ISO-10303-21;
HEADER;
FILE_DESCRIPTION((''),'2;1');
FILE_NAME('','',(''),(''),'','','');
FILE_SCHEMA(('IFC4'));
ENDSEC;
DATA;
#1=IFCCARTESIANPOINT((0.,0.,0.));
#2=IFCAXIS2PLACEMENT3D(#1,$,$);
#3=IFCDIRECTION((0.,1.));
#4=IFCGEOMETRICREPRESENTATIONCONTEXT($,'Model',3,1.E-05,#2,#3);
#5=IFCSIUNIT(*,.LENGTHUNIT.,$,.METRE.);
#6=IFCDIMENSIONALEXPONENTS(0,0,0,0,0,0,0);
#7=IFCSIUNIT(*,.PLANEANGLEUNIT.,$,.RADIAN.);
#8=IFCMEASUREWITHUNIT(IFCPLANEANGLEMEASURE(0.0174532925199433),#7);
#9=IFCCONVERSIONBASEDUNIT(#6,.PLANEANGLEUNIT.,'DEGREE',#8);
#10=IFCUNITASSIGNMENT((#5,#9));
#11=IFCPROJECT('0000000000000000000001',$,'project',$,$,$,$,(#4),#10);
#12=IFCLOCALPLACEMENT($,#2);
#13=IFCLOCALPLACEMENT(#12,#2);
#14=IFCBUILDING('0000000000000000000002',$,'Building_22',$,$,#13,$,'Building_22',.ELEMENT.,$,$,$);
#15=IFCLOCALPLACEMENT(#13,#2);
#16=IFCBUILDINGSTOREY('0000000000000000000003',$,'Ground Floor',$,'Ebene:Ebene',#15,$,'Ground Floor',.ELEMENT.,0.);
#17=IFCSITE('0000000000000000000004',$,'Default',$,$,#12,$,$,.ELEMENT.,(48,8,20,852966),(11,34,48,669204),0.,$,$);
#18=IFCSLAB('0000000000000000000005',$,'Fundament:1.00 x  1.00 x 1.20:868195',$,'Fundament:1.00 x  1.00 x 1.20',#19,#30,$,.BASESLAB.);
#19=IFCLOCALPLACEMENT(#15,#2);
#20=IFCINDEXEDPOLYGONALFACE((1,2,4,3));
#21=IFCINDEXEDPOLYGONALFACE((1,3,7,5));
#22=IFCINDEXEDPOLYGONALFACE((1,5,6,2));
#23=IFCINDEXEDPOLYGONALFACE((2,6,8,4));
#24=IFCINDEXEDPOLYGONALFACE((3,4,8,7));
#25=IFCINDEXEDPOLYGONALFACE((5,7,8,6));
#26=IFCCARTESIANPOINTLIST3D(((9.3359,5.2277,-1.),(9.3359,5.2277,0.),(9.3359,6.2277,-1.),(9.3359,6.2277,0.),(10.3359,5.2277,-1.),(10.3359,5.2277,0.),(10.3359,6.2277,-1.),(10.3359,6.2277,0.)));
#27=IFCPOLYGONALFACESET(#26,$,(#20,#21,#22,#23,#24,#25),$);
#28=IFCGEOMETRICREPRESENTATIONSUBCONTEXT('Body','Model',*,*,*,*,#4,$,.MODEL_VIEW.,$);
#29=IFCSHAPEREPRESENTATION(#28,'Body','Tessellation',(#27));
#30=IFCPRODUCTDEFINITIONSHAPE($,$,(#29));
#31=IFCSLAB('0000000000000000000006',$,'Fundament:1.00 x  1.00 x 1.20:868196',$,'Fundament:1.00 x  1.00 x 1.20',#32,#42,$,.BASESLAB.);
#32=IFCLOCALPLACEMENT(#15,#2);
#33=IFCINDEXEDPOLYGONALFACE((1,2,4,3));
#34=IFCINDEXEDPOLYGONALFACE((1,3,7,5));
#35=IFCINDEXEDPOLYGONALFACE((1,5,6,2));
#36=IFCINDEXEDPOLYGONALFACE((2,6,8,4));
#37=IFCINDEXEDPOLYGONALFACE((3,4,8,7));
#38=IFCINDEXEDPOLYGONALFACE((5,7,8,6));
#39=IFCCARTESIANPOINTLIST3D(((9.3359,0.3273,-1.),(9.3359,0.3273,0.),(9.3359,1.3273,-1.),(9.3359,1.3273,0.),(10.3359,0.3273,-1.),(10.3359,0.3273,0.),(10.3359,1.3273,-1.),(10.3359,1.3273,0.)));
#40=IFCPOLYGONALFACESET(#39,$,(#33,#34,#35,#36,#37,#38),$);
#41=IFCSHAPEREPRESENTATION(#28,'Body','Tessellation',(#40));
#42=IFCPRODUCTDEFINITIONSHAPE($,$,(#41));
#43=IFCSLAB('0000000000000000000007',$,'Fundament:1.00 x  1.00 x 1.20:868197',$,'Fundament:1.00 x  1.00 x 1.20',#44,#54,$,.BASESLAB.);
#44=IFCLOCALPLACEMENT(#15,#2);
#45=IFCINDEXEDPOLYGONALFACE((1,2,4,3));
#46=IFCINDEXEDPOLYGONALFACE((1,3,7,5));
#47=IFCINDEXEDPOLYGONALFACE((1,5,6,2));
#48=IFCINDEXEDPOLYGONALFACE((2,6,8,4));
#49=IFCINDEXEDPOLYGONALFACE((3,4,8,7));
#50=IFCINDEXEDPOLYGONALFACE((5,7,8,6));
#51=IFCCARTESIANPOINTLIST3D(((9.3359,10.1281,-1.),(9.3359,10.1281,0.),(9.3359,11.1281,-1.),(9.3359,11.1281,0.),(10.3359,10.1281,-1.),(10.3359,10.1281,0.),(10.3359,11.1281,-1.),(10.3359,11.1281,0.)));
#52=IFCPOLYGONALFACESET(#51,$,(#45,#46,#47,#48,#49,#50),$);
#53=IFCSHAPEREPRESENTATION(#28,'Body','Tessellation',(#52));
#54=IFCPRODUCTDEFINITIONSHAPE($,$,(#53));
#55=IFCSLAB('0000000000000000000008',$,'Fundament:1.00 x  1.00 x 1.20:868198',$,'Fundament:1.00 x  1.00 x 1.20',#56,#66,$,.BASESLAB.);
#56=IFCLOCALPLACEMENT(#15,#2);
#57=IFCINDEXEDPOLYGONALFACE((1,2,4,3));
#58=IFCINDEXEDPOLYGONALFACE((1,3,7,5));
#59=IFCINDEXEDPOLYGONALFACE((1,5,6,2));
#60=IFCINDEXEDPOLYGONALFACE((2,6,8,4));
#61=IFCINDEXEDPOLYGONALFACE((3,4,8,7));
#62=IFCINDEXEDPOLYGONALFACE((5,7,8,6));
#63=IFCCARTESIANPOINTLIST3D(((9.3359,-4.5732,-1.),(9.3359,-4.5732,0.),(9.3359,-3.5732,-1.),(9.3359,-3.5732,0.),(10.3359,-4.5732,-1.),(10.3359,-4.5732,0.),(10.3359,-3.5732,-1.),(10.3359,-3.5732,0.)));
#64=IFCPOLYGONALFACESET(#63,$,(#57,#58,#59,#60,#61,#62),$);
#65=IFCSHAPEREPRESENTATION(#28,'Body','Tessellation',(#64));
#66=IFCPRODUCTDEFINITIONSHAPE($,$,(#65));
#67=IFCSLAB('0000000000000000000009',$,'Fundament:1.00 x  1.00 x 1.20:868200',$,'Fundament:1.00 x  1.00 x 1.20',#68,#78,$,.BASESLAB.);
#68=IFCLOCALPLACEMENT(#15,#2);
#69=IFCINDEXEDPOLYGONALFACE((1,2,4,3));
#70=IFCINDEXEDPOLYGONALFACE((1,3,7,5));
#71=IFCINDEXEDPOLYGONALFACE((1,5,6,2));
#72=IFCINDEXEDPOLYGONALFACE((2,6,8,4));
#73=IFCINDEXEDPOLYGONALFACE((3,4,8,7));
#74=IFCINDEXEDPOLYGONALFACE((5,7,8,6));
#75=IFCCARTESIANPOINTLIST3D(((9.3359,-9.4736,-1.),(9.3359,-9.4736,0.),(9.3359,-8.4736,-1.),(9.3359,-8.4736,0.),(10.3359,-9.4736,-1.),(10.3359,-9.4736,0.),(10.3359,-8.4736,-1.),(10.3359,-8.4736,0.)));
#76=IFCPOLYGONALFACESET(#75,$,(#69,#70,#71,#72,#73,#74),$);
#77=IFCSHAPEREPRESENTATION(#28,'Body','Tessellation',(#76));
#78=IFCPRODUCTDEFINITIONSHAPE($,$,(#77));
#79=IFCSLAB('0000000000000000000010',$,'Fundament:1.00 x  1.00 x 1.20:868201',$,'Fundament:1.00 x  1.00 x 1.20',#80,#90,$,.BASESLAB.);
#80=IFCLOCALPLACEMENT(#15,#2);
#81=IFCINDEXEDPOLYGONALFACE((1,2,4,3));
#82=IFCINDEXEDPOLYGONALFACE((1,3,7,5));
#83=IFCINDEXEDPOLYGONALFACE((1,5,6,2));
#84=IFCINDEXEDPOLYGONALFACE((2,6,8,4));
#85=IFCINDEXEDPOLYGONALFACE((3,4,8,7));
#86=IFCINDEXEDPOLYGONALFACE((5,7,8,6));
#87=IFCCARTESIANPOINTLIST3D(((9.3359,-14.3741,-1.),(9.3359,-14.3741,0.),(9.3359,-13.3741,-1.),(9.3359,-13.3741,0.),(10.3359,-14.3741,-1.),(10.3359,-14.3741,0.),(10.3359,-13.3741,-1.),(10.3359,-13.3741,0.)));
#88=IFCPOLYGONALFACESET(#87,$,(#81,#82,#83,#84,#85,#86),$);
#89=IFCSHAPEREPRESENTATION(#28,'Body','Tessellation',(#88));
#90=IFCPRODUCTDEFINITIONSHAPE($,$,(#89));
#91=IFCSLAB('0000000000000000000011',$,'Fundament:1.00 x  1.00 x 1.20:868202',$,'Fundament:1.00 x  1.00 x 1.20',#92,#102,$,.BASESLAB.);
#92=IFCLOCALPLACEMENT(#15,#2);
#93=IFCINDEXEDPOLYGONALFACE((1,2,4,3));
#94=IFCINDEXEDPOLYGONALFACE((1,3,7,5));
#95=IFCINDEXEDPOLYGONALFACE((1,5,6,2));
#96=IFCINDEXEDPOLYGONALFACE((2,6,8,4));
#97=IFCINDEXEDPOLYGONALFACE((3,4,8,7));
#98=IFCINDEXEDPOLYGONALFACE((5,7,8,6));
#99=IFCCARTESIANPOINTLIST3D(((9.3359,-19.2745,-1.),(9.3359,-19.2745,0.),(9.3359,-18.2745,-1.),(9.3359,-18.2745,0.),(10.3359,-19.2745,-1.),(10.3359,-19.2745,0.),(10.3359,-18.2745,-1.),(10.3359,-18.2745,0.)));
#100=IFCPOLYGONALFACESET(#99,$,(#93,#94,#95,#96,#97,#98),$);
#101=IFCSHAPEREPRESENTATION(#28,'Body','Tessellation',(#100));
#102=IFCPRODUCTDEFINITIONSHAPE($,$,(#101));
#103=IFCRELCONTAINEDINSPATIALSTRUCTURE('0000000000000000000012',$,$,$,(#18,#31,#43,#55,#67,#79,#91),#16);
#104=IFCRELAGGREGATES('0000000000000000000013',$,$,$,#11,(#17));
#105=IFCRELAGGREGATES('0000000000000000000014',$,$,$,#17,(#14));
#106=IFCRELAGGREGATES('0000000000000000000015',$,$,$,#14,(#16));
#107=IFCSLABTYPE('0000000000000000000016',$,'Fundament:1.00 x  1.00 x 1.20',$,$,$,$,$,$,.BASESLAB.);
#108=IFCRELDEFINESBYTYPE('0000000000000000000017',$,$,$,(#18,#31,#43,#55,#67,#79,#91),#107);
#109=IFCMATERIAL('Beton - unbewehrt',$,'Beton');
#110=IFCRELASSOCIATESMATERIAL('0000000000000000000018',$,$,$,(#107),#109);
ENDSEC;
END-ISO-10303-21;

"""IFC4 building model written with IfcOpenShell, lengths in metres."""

from ifc_helpers import new_model, entity, si_unit, converted_unit, direction, frame, origin, place, context, subcontext, project, spatial, indexed_curve, outline, extrude, material, type_object, element, save


model = new_model("IFC4")

# Units and contexts
model_context = context("Model", 3, precision=1e-05, world=origin(), true_north=direction((0.0, 1.0)))
body_context = subcontext(model_context, "Body", "Model", "MODEL_VIEW")
ifc_project = project(units=[si_unit("LENGTHUNIT", "METRE"), converted_unit("PLANEANGLEUNIT", "DEGREE", entity("IfcPlaneAngleMeasure", 0.0174532925199433), si_unit("PLANEANGLEUNIT", "RADIAN"), dimensions=[0, 0, 0, 0, 0, 0, 0])], contexts=[model_context])

# Site, building, storey
site_placement = place(None, origin())
site = spatial("IfcSite", under=ifc_project, at=site_placement, Name="Default", CompositionType="ELEMENT", RefLatitude=(48, 8, 20, 852966), RefLongitude=(11, 34, 48, 669204), RefElevation=0.0)
building_placement = place(site_placement, origin())
building = spatial("IfcBuilding", under=site, at=building_placement, Name="Building_22", LongName="Building_22", CompositionType="ELEMENT")
storey_placement = place(building_placement, origin())
storey = spatial("IfcBuildingStorey", under=building, at=storey_placement, Name="Ground Floor", ObjectType="Ebene:Ebene", LongName="Ground Floor", CompositionType="ELEMENT", Elevation=0.0)

# Slabs
ifc_material_1 = material(Name="Beton - unbewehrt", Category="Beton")
slab_type = type_object("IfcSlabType", Name="Fundament:1.00 x  1.00 x 1.20", PredefinedType="BASESLAB", material=ifc_material_1)
slab_1_placement = place(storey_placement, origin())
element("IfcSlab", 1, at=slab_1_placement, inside=storey, type_object=slab_type, Name="Fundament:1.00 x  1.00 x 1.20:868195", ObjectType="Fundament:1.00 x  1.00 x 1.20", PredefinedType="BASESLAB", context=body_context, shape_type="SweptSolid", body=[
    extrude(outline(indexed_curve([(-0.5, -0.5), (0.5, -0.5), (0.5, 0.5), (-0.5, 0.5), (-0.5, -0.5)], self_intersect=False)), frame((9.8359, 5.7277, -1.0), z_axis=(0.0, 0.0, 1.0), x_axis=(0.0, -1.0, 0.0)), (0.0, 0.0, 1.0), 1.0),
])
slab_2_placement = place(storey_placement, origin())
element("IfcSlab", 2, at=slab_2_placement, inside=storey, type_object=slab_type, Name="Fundament:1.00 x  1.00 x 1.20:868196", ObjectType="Fundament:1.00 x  1.00 x 1.20", PredefinedType="BASESLAB", context=body_context, shape_type="SweptSolid", body=[
    extrude(outline(indexed_curve([(-0.5, -0.5), (0.5, -0.5), (0.5, 0.5), (-0.5, 0.5), (-0.5, -0.5)], self_intersect=False)), frame((9.8359, 0.8273, -1.0), z_axis=(0.0, 0.0, 1.0), x_axis=(0.0, -1.0, 0.0)), (0.0, 0.0, 1.0), 1.0),
])
slab_3_placement = place(storey_placement, origin())
element("IfcSlab", 3, at=slab_3_placement, inside=storey, type_object=slab_type, Name="Fundament:1.00 x  1.00 x 1.20:868197", ObjectType="Fundament:1.00 x  1.00 x 1.20", PredefinedType="BASESLAB", context=body_context, shape_type="SweptSolid", body=[
    extrude(outline(indexed_curve([(-0.5, -0.5), (0.5, -0.5), (0.5, 0.5), (-0.5, 0.5), (-0.5, -0.5)], self_intersect=False)), frame((9.8359, 10.6281, -1.0), z_axis=(0.0, 0.0, 1.0), x_axis=(0.0, -1.0, 0.0)), (0.0, 0.0, 1.0), 1.0),
])
slab_4_placement = place(storey_placement, origin())
element("IfcSlab", 4, at=slab_4_placement, inside=storey, type_object=slab_type, Name="Fundament:1.00 x  1.00 x 1.20:868198", ObjectType="Fundament:1.00 x  1.00 x 1.20", PredefinedType="BASESLAB", context=body_context, shape_type="SweptSolid", body=[
    extrude(outline(indexed_curve([(-0.5, -0.5), (0.5, -0.5), (0.5, 0.5), (-0.5, 0.5), (-0.5, -0.5)], self_intersect=False)), frame((9.8359, -4.0732, -1.0), z_axis=(0.0, 0.0, 1.0), x_axis=(0.0, -1.0, 0.0)), (0.0, 0.0, 1.0), 1.0),
])
slab_5_placement = place(storey_placement, origin())
element("IfcSlab", 5, at=slab_5_placement, inside=storey, type_object=slab_type, Name="Fundament:1.00 x  1.00 x 1.20:868200", ObjectType="Fundament:1.00 x  1.00 x 1.20", PredefinedType="BASESLAB", context=body_context, shape_type="SweptSolid", body=[
    extrude(outline(indexed_curve([(-0.5, -0.5), (0.5, -0.5), (0.5, 0.5), (-0.5, 0.5), (-0.5, -0.5)], self_intersect=False)), frame((9.8359, -8.9736, -1.0), z_axis=(0.0, 0.0, 1.0), x_axis=(0.0, -1.0, 0.0)), (0.0, 0.0, 1.0), 1.0),
])
slab_6_placement = place(storey_placement, origin())
element("IfcSlab", 6, at=slab_6_placement, inside=storey, type_object=slab_type, Name="Fundament:1.00 x  1.00 x 1.20:868201", ObjectType="Fundament:1.00 x  1.00 x 1.20", PredefinedType="BASESLAB", context=body_context, shape_type="SweptSolid", body=[
    extrude(outline(indexed_curve([(-0.5, -0.5), (0.5, -0.5), (0.5, 0.5), (-0.5, 0.5), (-0.5, -0.5)], self_intersect=False)), frame((9.8359, -13.8741, -1.0), z_axis=(0.0, 0.0, 1.0), x_axis=(0.0, -1.0, 0.0)), (0.0, 0.0, 1.0), 1.0),
])
slab_7_placement = place(storey_placement, origin())
element("IfcSlab", 7, at=slab_7_placement, inside=storey, type_object=slab_type, Name="Fundament:1.00 x  1.00 x 1.20:868202", ObjectType="Fundament:1.00 x  1.00 x 1.20", PredefinedType="BASESLAB", context=body_context, shape_type="SweptSolid", body=[
    extrude(outline(indexed_curve([(-0.5, -0.5), (0.5, -0.5), (0.5, 0.5), (-0.5, 0.5), (-0.5, -0.5)], self_intersect=False)), frame((9.8359, -18.7745, -1.0), z_axis=(0.0, 0.0, 1.0), x_axis=(0.0, -1.0, 0.0)), (0.0, 0.0, 1.0), 1.0),
])

save(model, "model.ifc")
